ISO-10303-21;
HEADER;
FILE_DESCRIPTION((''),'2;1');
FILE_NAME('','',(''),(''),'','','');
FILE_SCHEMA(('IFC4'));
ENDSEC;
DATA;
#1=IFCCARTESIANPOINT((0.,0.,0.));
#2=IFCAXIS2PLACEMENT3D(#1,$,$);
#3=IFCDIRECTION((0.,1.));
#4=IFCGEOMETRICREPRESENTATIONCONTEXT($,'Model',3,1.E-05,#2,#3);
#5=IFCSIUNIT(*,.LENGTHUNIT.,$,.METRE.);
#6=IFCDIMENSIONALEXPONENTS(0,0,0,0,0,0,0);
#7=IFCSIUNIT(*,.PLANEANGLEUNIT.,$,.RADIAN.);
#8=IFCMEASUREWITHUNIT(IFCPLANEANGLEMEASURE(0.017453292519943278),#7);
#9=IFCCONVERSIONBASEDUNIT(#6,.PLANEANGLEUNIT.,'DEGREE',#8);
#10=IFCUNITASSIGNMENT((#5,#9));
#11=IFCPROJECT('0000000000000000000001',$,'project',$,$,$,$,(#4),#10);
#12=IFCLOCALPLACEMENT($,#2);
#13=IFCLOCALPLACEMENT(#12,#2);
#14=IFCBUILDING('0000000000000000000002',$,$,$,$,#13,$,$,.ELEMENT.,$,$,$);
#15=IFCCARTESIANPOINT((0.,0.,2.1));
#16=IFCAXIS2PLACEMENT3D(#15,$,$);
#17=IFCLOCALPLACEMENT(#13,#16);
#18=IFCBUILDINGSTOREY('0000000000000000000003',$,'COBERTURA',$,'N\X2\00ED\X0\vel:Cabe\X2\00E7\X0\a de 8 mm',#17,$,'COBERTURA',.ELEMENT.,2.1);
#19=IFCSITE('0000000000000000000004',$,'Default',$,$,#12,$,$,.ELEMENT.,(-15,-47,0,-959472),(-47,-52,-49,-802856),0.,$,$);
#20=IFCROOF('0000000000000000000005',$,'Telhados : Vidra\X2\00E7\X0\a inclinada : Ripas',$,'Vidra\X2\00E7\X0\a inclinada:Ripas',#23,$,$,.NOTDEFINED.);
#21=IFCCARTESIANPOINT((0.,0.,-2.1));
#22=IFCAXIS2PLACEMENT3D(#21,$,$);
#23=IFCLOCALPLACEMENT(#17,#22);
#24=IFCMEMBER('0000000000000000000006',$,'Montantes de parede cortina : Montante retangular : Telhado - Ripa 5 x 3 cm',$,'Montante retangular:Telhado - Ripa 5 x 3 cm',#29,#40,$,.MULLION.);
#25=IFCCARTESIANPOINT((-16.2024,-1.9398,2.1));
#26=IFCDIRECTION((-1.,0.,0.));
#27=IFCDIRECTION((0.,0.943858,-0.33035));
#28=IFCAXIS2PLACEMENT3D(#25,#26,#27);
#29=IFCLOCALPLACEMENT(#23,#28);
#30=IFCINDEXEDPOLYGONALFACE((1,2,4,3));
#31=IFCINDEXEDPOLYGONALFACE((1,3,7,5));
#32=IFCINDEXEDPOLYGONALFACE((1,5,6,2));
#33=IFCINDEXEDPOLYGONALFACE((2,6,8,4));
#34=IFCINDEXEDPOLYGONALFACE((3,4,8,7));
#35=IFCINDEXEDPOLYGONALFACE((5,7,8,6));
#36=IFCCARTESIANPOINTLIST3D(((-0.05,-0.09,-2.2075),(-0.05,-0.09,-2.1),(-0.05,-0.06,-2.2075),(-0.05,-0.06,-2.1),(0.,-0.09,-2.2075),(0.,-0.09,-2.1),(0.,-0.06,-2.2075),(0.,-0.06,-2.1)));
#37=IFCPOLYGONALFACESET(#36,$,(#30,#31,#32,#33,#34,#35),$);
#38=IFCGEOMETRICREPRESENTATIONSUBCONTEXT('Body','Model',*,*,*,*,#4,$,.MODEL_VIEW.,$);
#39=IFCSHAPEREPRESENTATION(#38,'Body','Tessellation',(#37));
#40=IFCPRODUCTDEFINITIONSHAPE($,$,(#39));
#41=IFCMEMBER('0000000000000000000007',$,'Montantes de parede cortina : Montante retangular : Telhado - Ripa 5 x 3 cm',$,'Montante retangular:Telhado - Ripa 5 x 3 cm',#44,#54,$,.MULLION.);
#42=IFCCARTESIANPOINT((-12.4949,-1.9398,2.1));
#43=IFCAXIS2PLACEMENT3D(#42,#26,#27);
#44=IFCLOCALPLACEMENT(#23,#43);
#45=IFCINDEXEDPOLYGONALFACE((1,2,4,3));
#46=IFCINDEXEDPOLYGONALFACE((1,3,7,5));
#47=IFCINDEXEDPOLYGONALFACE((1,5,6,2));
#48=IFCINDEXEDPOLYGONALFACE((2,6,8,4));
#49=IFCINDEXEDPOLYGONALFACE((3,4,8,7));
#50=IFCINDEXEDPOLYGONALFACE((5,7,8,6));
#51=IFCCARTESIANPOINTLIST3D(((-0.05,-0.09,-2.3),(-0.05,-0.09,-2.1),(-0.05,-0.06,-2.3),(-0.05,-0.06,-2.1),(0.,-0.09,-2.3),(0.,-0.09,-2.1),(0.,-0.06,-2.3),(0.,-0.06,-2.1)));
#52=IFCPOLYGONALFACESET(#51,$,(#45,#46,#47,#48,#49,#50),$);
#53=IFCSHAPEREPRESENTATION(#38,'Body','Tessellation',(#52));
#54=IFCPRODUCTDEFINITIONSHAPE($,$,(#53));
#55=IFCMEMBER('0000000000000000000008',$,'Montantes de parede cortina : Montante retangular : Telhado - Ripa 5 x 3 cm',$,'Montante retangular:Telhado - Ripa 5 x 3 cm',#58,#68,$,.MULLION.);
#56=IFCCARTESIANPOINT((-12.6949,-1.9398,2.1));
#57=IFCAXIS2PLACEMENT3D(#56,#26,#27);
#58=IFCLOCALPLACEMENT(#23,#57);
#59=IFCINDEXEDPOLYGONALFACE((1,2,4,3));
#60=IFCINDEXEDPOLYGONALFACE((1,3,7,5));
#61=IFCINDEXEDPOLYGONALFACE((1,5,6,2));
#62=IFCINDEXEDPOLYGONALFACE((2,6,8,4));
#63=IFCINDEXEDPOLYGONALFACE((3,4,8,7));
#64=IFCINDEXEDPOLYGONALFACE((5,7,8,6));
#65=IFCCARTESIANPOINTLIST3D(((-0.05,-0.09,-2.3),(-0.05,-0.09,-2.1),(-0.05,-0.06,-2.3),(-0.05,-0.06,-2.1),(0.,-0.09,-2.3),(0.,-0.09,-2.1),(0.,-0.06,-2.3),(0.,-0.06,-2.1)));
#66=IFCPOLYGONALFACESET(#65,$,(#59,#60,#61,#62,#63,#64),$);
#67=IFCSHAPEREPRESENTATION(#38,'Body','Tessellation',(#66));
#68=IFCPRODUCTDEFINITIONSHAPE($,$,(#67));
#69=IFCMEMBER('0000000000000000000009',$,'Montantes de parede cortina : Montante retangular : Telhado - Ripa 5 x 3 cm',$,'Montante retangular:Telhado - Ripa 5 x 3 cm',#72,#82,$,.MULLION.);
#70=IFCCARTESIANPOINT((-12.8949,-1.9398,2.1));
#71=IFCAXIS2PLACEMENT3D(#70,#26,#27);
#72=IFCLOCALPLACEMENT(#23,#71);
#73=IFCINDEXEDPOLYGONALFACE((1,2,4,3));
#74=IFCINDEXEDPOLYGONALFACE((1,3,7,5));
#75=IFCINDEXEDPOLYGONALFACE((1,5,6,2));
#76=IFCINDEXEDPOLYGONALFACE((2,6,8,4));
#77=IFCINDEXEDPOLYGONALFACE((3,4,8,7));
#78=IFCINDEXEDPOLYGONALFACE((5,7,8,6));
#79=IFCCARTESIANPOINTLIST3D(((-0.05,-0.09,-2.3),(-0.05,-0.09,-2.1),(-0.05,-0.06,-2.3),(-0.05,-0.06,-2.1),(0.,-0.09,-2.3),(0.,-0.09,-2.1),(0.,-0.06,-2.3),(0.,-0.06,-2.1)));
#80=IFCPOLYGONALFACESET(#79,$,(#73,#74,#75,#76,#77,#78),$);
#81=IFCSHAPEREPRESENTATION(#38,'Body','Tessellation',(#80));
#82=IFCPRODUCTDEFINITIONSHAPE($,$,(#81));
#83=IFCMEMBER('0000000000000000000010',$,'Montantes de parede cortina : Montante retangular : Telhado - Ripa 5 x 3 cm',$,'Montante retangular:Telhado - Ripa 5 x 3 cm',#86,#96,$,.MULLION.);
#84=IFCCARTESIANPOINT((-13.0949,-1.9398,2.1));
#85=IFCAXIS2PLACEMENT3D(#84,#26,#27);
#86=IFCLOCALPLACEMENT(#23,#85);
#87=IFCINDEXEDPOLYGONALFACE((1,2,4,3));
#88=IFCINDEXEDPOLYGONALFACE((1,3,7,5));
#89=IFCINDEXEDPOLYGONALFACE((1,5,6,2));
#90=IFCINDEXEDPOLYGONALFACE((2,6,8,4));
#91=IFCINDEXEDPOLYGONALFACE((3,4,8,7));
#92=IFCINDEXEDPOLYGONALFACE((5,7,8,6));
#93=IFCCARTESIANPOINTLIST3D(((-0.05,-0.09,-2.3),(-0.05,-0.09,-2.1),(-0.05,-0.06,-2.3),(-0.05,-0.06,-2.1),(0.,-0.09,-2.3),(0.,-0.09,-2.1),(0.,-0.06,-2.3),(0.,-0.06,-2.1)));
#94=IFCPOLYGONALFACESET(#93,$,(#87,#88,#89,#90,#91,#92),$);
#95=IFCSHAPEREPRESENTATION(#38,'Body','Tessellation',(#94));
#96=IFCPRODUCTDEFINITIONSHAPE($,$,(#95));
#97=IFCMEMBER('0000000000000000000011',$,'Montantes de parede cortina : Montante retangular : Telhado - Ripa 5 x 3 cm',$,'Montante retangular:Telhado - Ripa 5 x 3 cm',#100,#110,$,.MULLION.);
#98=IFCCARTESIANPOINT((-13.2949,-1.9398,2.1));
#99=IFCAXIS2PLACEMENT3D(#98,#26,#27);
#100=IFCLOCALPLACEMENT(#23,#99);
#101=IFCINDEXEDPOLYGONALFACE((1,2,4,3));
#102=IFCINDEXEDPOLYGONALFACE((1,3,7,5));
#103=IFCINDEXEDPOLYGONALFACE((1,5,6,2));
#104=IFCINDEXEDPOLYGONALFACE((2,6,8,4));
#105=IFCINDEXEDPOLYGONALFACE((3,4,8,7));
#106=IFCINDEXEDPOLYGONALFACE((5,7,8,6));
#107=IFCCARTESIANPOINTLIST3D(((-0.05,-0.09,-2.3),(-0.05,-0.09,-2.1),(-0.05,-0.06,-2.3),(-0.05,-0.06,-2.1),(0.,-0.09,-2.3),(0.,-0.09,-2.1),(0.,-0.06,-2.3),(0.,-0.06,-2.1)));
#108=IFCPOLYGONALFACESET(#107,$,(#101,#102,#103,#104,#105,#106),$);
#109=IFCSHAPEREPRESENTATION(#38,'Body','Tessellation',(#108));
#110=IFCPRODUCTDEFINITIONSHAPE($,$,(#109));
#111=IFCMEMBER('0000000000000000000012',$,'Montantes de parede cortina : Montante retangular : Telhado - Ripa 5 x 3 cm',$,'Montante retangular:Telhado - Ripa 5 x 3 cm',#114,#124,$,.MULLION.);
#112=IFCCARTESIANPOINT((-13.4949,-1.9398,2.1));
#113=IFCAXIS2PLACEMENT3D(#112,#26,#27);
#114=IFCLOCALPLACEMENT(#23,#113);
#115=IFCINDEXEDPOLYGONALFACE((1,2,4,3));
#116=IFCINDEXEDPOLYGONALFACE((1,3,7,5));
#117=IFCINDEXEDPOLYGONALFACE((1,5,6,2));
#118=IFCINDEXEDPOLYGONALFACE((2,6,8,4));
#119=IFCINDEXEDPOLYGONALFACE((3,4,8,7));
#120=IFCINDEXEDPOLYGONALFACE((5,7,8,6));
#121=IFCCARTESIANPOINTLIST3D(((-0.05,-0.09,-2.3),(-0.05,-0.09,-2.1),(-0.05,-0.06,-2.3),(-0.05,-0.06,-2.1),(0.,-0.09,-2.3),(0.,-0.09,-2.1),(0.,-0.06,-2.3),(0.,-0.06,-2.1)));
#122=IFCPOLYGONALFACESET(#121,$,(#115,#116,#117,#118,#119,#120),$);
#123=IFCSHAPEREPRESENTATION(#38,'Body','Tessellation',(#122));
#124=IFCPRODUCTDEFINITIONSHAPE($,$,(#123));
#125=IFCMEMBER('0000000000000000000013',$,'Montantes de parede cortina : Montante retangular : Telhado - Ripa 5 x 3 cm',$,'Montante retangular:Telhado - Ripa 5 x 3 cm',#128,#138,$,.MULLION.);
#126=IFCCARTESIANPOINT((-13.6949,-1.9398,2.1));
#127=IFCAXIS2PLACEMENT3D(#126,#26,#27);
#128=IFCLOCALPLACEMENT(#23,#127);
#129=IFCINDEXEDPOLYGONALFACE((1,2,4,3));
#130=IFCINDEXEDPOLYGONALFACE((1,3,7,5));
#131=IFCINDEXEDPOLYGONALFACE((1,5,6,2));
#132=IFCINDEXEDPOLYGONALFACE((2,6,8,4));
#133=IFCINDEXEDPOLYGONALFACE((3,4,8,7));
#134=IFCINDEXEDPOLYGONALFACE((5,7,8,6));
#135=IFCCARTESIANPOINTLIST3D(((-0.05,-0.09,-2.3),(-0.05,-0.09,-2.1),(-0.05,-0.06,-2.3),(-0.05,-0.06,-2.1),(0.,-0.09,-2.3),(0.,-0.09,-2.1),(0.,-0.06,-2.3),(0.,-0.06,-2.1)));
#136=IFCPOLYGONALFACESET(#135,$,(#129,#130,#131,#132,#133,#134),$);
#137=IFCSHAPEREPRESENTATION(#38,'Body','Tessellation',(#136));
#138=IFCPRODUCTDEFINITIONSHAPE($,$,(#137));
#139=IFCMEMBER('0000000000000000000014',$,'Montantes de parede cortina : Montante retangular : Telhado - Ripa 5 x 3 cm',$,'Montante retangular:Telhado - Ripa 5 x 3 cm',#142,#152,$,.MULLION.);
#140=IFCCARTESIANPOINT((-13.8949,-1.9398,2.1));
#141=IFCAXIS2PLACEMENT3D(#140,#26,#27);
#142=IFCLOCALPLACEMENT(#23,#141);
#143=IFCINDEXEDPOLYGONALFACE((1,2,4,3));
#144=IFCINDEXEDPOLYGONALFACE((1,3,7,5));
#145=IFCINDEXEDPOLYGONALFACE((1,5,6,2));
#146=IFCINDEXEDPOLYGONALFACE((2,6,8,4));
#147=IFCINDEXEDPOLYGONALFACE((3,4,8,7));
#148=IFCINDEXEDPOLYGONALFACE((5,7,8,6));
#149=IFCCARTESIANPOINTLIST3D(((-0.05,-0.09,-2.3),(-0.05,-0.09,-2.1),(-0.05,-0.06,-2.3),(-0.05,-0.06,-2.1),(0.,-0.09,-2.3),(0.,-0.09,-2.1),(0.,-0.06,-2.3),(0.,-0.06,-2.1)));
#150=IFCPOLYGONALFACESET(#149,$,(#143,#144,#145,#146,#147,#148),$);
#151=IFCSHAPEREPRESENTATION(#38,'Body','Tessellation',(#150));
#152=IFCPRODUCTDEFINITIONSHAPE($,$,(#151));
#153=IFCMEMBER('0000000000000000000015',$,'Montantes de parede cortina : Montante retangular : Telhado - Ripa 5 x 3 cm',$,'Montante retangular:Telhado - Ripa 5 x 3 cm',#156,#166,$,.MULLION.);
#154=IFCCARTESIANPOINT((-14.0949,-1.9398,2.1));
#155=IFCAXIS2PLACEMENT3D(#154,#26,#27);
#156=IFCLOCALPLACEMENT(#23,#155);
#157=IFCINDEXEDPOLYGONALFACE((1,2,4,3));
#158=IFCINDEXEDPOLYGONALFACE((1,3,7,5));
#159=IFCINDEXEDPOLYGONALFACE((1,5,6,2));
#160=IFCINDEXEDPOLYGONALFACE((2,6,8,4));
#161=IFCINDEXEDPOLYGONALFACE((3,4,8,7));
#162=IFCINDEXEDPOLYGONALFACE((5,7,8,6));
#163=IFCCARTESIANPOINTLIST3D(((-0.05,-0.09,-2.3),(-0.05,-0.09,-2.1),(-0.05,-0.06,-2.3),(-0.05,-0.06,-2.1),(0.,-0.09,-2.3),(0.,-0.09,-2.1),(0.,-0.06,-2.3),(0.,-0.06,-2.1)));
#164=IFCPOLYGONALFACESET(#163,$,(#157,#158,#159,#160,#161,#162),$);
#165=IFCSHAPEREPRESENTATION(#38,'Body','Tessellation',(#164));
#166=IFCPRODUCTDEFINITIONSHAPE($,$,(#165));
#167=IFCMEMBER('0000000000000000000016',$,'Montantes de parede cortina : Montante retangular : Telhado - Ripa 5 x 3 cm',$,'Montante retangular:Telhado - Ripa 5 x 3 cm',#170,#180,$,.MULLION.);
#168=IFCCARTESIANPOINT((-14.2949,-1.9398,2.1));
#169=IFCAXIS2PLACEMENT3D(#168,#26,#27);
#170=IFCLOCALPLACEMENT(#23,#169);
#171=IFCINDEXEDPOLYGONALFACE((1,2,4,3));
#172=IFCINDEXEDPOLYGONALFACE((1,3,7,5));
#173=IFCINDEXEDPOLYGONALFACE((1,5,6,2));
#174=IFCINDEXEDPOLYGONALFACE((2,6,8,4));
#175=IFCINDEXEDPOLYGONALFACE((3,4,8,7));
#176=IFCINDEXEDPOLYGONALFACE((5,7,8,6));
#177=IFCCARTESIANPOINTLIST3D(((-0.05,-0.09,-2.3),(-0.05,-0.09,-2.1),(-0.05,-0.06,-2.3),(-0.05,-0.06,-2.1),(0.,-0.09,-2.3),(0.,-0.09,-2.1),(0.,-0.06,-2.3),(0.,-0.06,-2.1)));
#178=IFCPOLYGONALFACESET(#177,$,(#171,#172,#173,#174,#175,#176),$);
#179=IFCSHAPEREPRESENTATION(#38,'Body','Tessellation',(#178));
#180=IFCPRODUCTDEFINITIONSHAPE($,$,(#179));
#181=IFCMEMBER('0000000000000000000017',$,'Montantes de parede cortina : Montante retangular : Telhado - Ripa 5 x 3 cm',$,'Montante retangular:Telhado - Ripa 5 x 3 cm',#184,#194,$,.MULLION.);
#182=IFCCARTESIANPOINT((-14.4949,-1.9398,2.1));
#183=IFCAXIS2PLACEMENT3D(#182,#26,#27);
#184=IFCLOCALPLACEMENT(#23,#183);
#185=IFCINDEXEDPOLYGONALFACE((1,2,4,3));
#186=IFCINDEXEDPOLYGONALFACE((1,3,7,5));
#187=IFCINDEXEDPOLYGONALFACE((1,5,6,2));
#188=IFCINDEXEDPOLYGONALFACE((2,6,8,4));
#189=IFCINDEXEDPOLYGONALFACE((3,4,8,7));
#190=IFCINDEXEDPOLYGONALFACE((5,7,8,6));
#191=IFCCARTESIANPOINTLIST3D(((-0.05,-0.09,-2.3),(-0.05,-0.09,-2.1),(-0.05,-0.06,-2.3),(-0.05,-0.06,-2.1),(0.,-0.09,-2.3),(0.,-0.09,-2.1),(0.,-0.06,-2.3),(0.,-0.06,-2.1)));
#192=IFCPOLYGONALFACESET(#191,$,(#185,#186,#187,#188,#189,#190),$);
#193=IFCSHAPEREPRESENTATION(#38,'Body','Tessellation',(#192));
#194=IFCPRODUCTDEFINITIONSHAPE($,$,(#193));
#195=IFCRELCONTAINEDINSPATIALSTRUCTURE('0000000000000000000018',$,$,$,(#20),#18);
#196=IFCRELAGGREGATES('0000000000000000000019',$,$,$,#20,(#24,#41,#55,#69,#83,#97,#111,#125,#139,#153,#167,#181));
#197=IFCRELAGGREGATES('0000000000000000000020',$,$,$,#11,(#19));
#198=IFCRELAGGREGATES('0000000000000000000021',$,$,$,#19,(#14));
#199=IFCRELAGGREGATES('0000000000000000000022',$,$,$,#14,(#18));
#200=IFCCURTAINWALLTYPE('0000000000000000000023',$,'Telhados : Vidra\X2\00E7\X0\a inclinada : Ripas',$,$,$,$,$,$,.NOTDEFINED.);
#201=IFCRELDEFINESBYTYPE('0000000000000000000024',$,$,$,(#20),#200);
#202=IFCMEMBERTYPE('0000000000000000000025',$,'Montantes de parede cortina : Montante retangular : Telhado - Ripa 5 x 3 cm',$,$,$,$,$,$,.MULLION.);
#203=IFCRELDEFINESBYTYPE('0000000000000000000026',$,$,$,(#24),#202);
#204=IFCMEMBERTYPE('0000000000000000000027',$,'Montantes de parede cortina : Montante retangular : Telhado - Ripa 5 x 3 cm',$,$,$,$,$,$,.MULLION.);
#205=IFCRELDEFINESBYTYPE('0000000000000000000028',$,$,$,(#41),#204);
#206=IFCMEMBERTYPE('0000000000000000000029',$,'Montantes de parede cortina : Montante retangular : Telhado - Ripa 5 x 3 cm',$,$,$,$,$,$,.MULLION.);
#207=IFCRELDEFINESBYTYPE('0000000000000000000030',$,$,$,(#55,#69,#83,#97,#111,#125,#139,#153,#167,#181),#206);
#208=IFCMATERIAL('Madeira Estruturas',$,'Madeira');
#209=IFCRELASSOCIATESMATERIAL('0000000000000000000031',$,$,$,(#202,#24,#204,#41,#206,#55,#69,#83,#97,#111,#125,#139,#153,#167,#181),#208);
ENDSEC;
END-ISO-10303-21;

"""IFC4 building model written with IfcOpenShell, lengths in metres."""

from ifc_helpers import new_model, entity, si_unit, converted_unit, direction, frame, origin, place, context, subcontext, project, spatial, indexed_curve, outline, extrude, source, transform, mapped, material, type_object, type_shapes, element, aggregate, save


model = new_model("IFC4")

# Units and contexts
model_context = context("Model", 3, precision=1e-05, world=origin(), true_north=direction((0.0, 1.0)))
body_context = subcontext(model_context, "Body", "Model", "MODEL_VIEW")
ifc_project = project(units=[si_unit("LENGTHUNIT", "METRE"), converted_unit("PLANEANGLEUNIT", "DEGREE", entity("IfcPlaneAngleMeasure", 0.017453292519943278), si_unit("PLANEANGLEUNIT", "RADIAN"), dimensions=[0, 0, 0, 0, 0, 0, 0])], contexts=[model_context])

# Site, building, storey
site_placement = place(None, origin())
site = spatial("IfcSite", under=ifc_project, at=site_placement, Name="Default", CompositionType="ELEMENT", RefLatitude=(-15, -47, 0, -959472), RefLongitude=(-47, -52, -49, -802856), RefElevation=0.0)
building_placement = place(site_placement, origin())
building = spatial("IfcBuilding", under=site, at=building_placement, CompositionType="ELEMENT")
storey_placement = place(building_placement, frame((0.0, 0.0, 2.1)))
storey = spatial("IfcBuildingStorey", under=building, at=storey_placement, Name="COBERTURA", ObjectType="Nível:Cabeça de 8 mm", LongName="COBERTURA", CompositionType="ELEMENT", Elevation=2.1)

# Roof, members
curtain_wall_type_1 = type_object("IfcCurtainWallType", Name="Telhados : Vidraça inclinada : Ripas", PredefinedType="NOTDEFINED")
roof_1_placement = place(storey_placement, frame((0.0, 0.0, -2.1)))
roof_1 = element("IfcRoof", 1, at=roof_1_placement, inside=storey, type_object=curtain_wall_type_1, Name="Telhados : Vidraça inclinada : Ripas", ObjectType="Vidraça inclinada:Ripas", PredefinedType="NOTDEFINED")
ifc_material_1 = material(Name="Madeira Estruturas", Category="Madeira")
member_type_1 = type_object("IfcMemberType", Name="Montantes de parede cortina : Montante retangular : Telhado - Ripa 5 x 3 cm", PredefinedType="MULLION", material=ifc_material_1)
shared_shape_1 = source(origin(), body_context, "Body", "SweptSolid", [
    extrude(outline(indexed_curve([(-0.025, -0.015), (0.025, -0.015), (0.025, 0.015), (-0.025, 0.015), (-0.025, -0.015)], self_intersect=False)), frame((-0.025, -0.075, -2.2075), z_axis=(0.0, 0.0, 1.0), x_axis=(-1.0, 0.0, 0.0)), (0.0, 0.0, 1.0), 0.1075),
])
type_shapes(member_type_1, [shared_shape_1])
member_1_placement = place(roof_1_placement, frame((-16.2024, -1.9398, 2.1), z_axis=(-1.0, 0.0, 0.0), x_axis=(0.0, 0.943858, -0.33035)))
member_1 = element("IfcMember", 2, at=member_1_placement, type_object=member_type_1, material=ifc_material_1, Name="Montantes de parede cortina : Montante retangular : Telhado - Ripa 5 x 3 cm", ObjectType="Montante retangular:Telhado - Ripa 5 x 3 cm", PredefinedType="MULLION", context=body_context, shape_type="MappedRepresentation", body=[
    mapped(shared_shape_1, transform((0.0, 0.0, 0.0), scale=1.0)),
])
member_type_2 = type_object("IfcMemberType", Name="Montantes de parede cortina : Montante retangular : Telhado - Ripa 5 x 3 cm", PredefinedType="MULLION", material=ifc_material_1)
shared_shape_2 = source(origin(), body_context, "Body", "SweptSolid", [
    extrude(outline(indexed_curve([(-0.025, -0.015), (0.025, -0.015), (0.025, 0.015), (-0.025, 0.015), (-0.025, -0.015)], self_intersect=False)), frame((-0.025, -0.075, -2.3), z_axis=(0.0, 0.0, 1.0), x_axis=(-1.0, 0.0, 0.0)), (0.0, 0.0, 1.0), 0.2),
])
type_shapes(member_type_2, [shared_shape_2])
member_2_placement = place(roof_1_placement, frame((-12.4949, -1.9398, 2.1), z_axis=(-1.0, 0.0, 0.0), x_axis=(0.0, 0.943858, -0.33035)))
member_2 = element("IfcMember", 3, at=member_2_placement, type_object=member_type_2, material=ifc_material_1, Name="Montantes de parede cortina : Montante retangular : Telhado - Ripa 5 x 3 cm", ObjectType="Montante retangular:Telhado - Ripa 5 x 3 cm", PredefinedType="MULLION", context=body_context, shape_type="MappedRepresentation", body=[
    mapped(shared_shape_2, transform((0.0, 0.0, 0.0), scale=1.0)),
])
member_type_3 = type_object("IfcMemberType", Name="Montantes de parede cortina : Montante retangular : Telhado - Ripa 5 x 3 cm", PredefinedType="MULLION", material=ifc_material_1)
shared_shape_3 = source(origin(), body_context, "Body", "SweptSolid", [
    extrude(outline(indexed_curve([(-0.025, -0.015), (0.025, -0.015), (0.025, 0.015), (-0.025, 0.015), (-0.025, -0.015)], self_intersect=False)), frame((-0.025, -0.075, -2.3), z_axis=(0.0, 0.0, 1.0), x_axis=(-1.0, 0.0, 0.0)), (0.0, 0.0, 1.0), 0.2),
])
type_shapes(member_type_3, [shared_shape_3])
member_3_placement = place(roof_1_placement, frame((-12.6949, -1.9398, 2.1), z_axis=(-1.0, 0.0, 0.0), x_axis=(0.0, 0.943858, -0.33035)))
member_3 = element("IfcMember", 4, at=member_3_placement, type_object=member_type_3, material=ifc_material_1, Name="Montantes de parede cortina : Montante retangular : Telhado - Ripa 5 x 3 cm", ObjectType="Montante retangular:Telhado - Ripa 5 x 3 cm", PredefinedType="MULLION", context=body_context, shape_type="MappedRepresentation", body=[
    mapped(shared_shape_3, transform((0.0, 0.0, 0.0), scale=1.0)),
])
member_4_placement = place(roof_1_placement, frame((-12.8949, -1.9398, 2.1), z_axis=(-1.0, 0.0, 0.0), x_axis=(0.0, 0.943858, -0.33035)))
member_4 = element("IfcMember", 5, at=member_4_placement, type_object=member_type_3, material=ifc_material_1, Name="Montantes de parede cortina : Montante retangular : Telhado - Ripa 5 x 3 cm", ObjectType="Montante retangular:Telhado - Ripa 5 x 3 cm", PredefinedType="MULLION", context=body_context, shape_type="MappedRepresentation", body=[
    mapped(shared_shape_3, transform((0.0, 0.0, 0.0), scale=1.0)),
])
member_5_placement = place(roof_1_placement, frame((-13.0949, -1.9398, 2.1), z_axis=(-1.0, 0.0, 0.0), x_axis=(0.0, 0.943858, -0.33035)))
member_5 = element("IfcMember", 6, at=member_5_placement, type_object=member_type_3, material=ifc_material_1, Name="Montantes de parede cortina : Montante retangular : Telhado - Ripa 5 x 3 cm", ObjectType="Montante retangular:Telhado - Ripa 5 x 3 cm", PredefinedType="MULLION", context=body_context, shape_type="MappedRepresentation", body=[
    mapped(shared_shape_3, transform((0.0, 0.0, 0.0), scale=1.0)),
])
member_6_placement = place(roof_1_placement, frame((-13.2949, -1.9398, 2.1), z_axis=(-1.0, 0.0, 0.0), x_axis=(0.0, 0.943858, -0.33035)))
member_6 = element("IfcMember", 7, at=member_6_placement, type_object=member_type_3, material=ifc_material_1, Name="Montantes de parede cortina : Montante retangular : Telhado - Ripa 5 x 3 cm", ObjectType="Montante retangular:Telhado - Ripa 5 x 3 cm", PredefinedType="MULLION", context=body_context, shape_type="MappedRepresentation", body=[
    mapped(shared_shape_3, transform((0.0, 0.0, 0.0), scale=1.0)),
])
member_7_placement = place(roof_1_placement, frame((-13.4949, -1.9398, 2.1), z_axis=(-1.0, 0.0, 0.0), x_axis=(0.0, 0.943858, -0.33035)))
member_7 = element("IfcMember", 8, at=member_7_placement, type_object=member_type_3, material=ifc_material_1, Name="Montantes de parede cortina : Montante retangular : Telhado - Ripa 5 x 3 cm", ObjectType="Montante retangular:Telhado - Ripa 5 x 3 cm", PredefinedType="MULLION", context=body_context, shape_type="MappedRepresentation", body=[
    mapped(shared_shape_3, transform((0.0, 0.0, 0.0), scale=1.0)),
])
member_8_placement = place(roof_1_placement, frame((-13.6949, -1.9398, 2.1), z_axis=(-1.0, 0.0, 0.0), x_axis=(0.0, 0.943858, -0.33035)))
member_8 = element("IfcMember", 9, at=member_8_placement, type_object=member_type_3, material=ifc_material_1, Name="Montantes de parede cortina : Montante retangular : Telhado - Ripa 5 x 3 cm", ObjectType="Montante retangular:Telhado - Ripa 5 x 3 cm", PredefinedType="MULLION", context=body_context, shape_type="MappedRepresentation", body=[
    mapped(shared_shape_3, transform((0.0, 0.0, 0.0), scale=1.0)),
])
member_9_placement = place(roof_1_placement, frame((-13.8949, -1.9398, 2.1), z_axis=(-1.0, 0.0, 0.0), x_axis=(0.0, 0.943858, -0.33035)))
member_9 = element("IfcMember", 10, at=member_9_placement, type_object=member_type_3, material=ifc_material_1, Name="Montantes de parede cortina : Montante retangular : Telhado - Ripa 5 x 3 cm", ObjectType="Montante retangular:Telhado - Ripa 5 x 3 cm", PredefinedType="MULLION", context=body_context, shape_type="MappedRepresentation", body=[
    mapped(shared_shape_3, transform((0.0, 0.0, 0.0), scale=1.0)),
])
member_10_placement = place(roof_1_placement, frame((-14.0949, -1.9398, 2.1), z_axis=(-1.0, 0.0, 0.0), x_axis=(0.0, 0.943858, -0.33035)))
member_10 = element("IfcMember", 11, at=member_10_placement, type_object=member_type_3, material=ifc_material_1, Name="Montantes de parede cortina : Montante retangular : Telhado - Ripa 5 x 3 cm", ObjectType="Montante retangular:Telhado - Ripa 5 x 3 cm", PredefinedType="MULLION", context=body_context, shape_type="MappedRepresentation", body=[
    mapped(shared_shape_3, transform((0.0, 0.0, 0.0), scale=1.0)),
])
member_11_placement = place(roof_1_placement, frame((-14.2949, -1.9398, 2.1), z_axis=(-1.0, 0.0, 0.0), x_axis=(0.0, 0.943858, -0.33035)))
member_11 = element("IfcMember", 12, at=member_11_placement, type_object=member_type_3, material=ifc_material_1, Name="Montantes de parede cortina : Montante retangular : Telhado - Ripa 5 x 3 cm", ObjectType="Montante retangular:Telhado - Ripa 5 x 3 cm", PredefinedType="MULLION", context=body_context, shape_type="MappedRepresentation", body=[
    mapped(shared_shape_3, transform((0.0, 0.0, 0.0), scale=1.0)),
])
member_12_placement = place(roof_1_placement, frame((-14.4949, -1.9398, 2.1), z_axis=(-1.0, 0.0, 0.0), x_axis=(0.0, 0.943858, -0.33035)))
member_12 = element("IfcMember", 13, at=member_12_placement, type_object=member_type_3, material=ifc_material_1, Name="Montantes de parede cortina : Montante retangular : Telhado - Ripa 5 x 3 cm", ObjectType="Montante retangular:Telhado - Ripa 5 x 3 cm", PredefinedType="MULLION", context=body_context, shape_type="MappedRepresentation", body=[
    mapped(shared_shape_3, transform((0.0, 0.0, 0.0), scale=1.0)),
])
aggregate(roof_1, [member_1, member_2, member_3, member_4, member_5, member_6, member_7, member_8, member_9, member_10, member_11, member_12])

save(model, "model.ifc")
